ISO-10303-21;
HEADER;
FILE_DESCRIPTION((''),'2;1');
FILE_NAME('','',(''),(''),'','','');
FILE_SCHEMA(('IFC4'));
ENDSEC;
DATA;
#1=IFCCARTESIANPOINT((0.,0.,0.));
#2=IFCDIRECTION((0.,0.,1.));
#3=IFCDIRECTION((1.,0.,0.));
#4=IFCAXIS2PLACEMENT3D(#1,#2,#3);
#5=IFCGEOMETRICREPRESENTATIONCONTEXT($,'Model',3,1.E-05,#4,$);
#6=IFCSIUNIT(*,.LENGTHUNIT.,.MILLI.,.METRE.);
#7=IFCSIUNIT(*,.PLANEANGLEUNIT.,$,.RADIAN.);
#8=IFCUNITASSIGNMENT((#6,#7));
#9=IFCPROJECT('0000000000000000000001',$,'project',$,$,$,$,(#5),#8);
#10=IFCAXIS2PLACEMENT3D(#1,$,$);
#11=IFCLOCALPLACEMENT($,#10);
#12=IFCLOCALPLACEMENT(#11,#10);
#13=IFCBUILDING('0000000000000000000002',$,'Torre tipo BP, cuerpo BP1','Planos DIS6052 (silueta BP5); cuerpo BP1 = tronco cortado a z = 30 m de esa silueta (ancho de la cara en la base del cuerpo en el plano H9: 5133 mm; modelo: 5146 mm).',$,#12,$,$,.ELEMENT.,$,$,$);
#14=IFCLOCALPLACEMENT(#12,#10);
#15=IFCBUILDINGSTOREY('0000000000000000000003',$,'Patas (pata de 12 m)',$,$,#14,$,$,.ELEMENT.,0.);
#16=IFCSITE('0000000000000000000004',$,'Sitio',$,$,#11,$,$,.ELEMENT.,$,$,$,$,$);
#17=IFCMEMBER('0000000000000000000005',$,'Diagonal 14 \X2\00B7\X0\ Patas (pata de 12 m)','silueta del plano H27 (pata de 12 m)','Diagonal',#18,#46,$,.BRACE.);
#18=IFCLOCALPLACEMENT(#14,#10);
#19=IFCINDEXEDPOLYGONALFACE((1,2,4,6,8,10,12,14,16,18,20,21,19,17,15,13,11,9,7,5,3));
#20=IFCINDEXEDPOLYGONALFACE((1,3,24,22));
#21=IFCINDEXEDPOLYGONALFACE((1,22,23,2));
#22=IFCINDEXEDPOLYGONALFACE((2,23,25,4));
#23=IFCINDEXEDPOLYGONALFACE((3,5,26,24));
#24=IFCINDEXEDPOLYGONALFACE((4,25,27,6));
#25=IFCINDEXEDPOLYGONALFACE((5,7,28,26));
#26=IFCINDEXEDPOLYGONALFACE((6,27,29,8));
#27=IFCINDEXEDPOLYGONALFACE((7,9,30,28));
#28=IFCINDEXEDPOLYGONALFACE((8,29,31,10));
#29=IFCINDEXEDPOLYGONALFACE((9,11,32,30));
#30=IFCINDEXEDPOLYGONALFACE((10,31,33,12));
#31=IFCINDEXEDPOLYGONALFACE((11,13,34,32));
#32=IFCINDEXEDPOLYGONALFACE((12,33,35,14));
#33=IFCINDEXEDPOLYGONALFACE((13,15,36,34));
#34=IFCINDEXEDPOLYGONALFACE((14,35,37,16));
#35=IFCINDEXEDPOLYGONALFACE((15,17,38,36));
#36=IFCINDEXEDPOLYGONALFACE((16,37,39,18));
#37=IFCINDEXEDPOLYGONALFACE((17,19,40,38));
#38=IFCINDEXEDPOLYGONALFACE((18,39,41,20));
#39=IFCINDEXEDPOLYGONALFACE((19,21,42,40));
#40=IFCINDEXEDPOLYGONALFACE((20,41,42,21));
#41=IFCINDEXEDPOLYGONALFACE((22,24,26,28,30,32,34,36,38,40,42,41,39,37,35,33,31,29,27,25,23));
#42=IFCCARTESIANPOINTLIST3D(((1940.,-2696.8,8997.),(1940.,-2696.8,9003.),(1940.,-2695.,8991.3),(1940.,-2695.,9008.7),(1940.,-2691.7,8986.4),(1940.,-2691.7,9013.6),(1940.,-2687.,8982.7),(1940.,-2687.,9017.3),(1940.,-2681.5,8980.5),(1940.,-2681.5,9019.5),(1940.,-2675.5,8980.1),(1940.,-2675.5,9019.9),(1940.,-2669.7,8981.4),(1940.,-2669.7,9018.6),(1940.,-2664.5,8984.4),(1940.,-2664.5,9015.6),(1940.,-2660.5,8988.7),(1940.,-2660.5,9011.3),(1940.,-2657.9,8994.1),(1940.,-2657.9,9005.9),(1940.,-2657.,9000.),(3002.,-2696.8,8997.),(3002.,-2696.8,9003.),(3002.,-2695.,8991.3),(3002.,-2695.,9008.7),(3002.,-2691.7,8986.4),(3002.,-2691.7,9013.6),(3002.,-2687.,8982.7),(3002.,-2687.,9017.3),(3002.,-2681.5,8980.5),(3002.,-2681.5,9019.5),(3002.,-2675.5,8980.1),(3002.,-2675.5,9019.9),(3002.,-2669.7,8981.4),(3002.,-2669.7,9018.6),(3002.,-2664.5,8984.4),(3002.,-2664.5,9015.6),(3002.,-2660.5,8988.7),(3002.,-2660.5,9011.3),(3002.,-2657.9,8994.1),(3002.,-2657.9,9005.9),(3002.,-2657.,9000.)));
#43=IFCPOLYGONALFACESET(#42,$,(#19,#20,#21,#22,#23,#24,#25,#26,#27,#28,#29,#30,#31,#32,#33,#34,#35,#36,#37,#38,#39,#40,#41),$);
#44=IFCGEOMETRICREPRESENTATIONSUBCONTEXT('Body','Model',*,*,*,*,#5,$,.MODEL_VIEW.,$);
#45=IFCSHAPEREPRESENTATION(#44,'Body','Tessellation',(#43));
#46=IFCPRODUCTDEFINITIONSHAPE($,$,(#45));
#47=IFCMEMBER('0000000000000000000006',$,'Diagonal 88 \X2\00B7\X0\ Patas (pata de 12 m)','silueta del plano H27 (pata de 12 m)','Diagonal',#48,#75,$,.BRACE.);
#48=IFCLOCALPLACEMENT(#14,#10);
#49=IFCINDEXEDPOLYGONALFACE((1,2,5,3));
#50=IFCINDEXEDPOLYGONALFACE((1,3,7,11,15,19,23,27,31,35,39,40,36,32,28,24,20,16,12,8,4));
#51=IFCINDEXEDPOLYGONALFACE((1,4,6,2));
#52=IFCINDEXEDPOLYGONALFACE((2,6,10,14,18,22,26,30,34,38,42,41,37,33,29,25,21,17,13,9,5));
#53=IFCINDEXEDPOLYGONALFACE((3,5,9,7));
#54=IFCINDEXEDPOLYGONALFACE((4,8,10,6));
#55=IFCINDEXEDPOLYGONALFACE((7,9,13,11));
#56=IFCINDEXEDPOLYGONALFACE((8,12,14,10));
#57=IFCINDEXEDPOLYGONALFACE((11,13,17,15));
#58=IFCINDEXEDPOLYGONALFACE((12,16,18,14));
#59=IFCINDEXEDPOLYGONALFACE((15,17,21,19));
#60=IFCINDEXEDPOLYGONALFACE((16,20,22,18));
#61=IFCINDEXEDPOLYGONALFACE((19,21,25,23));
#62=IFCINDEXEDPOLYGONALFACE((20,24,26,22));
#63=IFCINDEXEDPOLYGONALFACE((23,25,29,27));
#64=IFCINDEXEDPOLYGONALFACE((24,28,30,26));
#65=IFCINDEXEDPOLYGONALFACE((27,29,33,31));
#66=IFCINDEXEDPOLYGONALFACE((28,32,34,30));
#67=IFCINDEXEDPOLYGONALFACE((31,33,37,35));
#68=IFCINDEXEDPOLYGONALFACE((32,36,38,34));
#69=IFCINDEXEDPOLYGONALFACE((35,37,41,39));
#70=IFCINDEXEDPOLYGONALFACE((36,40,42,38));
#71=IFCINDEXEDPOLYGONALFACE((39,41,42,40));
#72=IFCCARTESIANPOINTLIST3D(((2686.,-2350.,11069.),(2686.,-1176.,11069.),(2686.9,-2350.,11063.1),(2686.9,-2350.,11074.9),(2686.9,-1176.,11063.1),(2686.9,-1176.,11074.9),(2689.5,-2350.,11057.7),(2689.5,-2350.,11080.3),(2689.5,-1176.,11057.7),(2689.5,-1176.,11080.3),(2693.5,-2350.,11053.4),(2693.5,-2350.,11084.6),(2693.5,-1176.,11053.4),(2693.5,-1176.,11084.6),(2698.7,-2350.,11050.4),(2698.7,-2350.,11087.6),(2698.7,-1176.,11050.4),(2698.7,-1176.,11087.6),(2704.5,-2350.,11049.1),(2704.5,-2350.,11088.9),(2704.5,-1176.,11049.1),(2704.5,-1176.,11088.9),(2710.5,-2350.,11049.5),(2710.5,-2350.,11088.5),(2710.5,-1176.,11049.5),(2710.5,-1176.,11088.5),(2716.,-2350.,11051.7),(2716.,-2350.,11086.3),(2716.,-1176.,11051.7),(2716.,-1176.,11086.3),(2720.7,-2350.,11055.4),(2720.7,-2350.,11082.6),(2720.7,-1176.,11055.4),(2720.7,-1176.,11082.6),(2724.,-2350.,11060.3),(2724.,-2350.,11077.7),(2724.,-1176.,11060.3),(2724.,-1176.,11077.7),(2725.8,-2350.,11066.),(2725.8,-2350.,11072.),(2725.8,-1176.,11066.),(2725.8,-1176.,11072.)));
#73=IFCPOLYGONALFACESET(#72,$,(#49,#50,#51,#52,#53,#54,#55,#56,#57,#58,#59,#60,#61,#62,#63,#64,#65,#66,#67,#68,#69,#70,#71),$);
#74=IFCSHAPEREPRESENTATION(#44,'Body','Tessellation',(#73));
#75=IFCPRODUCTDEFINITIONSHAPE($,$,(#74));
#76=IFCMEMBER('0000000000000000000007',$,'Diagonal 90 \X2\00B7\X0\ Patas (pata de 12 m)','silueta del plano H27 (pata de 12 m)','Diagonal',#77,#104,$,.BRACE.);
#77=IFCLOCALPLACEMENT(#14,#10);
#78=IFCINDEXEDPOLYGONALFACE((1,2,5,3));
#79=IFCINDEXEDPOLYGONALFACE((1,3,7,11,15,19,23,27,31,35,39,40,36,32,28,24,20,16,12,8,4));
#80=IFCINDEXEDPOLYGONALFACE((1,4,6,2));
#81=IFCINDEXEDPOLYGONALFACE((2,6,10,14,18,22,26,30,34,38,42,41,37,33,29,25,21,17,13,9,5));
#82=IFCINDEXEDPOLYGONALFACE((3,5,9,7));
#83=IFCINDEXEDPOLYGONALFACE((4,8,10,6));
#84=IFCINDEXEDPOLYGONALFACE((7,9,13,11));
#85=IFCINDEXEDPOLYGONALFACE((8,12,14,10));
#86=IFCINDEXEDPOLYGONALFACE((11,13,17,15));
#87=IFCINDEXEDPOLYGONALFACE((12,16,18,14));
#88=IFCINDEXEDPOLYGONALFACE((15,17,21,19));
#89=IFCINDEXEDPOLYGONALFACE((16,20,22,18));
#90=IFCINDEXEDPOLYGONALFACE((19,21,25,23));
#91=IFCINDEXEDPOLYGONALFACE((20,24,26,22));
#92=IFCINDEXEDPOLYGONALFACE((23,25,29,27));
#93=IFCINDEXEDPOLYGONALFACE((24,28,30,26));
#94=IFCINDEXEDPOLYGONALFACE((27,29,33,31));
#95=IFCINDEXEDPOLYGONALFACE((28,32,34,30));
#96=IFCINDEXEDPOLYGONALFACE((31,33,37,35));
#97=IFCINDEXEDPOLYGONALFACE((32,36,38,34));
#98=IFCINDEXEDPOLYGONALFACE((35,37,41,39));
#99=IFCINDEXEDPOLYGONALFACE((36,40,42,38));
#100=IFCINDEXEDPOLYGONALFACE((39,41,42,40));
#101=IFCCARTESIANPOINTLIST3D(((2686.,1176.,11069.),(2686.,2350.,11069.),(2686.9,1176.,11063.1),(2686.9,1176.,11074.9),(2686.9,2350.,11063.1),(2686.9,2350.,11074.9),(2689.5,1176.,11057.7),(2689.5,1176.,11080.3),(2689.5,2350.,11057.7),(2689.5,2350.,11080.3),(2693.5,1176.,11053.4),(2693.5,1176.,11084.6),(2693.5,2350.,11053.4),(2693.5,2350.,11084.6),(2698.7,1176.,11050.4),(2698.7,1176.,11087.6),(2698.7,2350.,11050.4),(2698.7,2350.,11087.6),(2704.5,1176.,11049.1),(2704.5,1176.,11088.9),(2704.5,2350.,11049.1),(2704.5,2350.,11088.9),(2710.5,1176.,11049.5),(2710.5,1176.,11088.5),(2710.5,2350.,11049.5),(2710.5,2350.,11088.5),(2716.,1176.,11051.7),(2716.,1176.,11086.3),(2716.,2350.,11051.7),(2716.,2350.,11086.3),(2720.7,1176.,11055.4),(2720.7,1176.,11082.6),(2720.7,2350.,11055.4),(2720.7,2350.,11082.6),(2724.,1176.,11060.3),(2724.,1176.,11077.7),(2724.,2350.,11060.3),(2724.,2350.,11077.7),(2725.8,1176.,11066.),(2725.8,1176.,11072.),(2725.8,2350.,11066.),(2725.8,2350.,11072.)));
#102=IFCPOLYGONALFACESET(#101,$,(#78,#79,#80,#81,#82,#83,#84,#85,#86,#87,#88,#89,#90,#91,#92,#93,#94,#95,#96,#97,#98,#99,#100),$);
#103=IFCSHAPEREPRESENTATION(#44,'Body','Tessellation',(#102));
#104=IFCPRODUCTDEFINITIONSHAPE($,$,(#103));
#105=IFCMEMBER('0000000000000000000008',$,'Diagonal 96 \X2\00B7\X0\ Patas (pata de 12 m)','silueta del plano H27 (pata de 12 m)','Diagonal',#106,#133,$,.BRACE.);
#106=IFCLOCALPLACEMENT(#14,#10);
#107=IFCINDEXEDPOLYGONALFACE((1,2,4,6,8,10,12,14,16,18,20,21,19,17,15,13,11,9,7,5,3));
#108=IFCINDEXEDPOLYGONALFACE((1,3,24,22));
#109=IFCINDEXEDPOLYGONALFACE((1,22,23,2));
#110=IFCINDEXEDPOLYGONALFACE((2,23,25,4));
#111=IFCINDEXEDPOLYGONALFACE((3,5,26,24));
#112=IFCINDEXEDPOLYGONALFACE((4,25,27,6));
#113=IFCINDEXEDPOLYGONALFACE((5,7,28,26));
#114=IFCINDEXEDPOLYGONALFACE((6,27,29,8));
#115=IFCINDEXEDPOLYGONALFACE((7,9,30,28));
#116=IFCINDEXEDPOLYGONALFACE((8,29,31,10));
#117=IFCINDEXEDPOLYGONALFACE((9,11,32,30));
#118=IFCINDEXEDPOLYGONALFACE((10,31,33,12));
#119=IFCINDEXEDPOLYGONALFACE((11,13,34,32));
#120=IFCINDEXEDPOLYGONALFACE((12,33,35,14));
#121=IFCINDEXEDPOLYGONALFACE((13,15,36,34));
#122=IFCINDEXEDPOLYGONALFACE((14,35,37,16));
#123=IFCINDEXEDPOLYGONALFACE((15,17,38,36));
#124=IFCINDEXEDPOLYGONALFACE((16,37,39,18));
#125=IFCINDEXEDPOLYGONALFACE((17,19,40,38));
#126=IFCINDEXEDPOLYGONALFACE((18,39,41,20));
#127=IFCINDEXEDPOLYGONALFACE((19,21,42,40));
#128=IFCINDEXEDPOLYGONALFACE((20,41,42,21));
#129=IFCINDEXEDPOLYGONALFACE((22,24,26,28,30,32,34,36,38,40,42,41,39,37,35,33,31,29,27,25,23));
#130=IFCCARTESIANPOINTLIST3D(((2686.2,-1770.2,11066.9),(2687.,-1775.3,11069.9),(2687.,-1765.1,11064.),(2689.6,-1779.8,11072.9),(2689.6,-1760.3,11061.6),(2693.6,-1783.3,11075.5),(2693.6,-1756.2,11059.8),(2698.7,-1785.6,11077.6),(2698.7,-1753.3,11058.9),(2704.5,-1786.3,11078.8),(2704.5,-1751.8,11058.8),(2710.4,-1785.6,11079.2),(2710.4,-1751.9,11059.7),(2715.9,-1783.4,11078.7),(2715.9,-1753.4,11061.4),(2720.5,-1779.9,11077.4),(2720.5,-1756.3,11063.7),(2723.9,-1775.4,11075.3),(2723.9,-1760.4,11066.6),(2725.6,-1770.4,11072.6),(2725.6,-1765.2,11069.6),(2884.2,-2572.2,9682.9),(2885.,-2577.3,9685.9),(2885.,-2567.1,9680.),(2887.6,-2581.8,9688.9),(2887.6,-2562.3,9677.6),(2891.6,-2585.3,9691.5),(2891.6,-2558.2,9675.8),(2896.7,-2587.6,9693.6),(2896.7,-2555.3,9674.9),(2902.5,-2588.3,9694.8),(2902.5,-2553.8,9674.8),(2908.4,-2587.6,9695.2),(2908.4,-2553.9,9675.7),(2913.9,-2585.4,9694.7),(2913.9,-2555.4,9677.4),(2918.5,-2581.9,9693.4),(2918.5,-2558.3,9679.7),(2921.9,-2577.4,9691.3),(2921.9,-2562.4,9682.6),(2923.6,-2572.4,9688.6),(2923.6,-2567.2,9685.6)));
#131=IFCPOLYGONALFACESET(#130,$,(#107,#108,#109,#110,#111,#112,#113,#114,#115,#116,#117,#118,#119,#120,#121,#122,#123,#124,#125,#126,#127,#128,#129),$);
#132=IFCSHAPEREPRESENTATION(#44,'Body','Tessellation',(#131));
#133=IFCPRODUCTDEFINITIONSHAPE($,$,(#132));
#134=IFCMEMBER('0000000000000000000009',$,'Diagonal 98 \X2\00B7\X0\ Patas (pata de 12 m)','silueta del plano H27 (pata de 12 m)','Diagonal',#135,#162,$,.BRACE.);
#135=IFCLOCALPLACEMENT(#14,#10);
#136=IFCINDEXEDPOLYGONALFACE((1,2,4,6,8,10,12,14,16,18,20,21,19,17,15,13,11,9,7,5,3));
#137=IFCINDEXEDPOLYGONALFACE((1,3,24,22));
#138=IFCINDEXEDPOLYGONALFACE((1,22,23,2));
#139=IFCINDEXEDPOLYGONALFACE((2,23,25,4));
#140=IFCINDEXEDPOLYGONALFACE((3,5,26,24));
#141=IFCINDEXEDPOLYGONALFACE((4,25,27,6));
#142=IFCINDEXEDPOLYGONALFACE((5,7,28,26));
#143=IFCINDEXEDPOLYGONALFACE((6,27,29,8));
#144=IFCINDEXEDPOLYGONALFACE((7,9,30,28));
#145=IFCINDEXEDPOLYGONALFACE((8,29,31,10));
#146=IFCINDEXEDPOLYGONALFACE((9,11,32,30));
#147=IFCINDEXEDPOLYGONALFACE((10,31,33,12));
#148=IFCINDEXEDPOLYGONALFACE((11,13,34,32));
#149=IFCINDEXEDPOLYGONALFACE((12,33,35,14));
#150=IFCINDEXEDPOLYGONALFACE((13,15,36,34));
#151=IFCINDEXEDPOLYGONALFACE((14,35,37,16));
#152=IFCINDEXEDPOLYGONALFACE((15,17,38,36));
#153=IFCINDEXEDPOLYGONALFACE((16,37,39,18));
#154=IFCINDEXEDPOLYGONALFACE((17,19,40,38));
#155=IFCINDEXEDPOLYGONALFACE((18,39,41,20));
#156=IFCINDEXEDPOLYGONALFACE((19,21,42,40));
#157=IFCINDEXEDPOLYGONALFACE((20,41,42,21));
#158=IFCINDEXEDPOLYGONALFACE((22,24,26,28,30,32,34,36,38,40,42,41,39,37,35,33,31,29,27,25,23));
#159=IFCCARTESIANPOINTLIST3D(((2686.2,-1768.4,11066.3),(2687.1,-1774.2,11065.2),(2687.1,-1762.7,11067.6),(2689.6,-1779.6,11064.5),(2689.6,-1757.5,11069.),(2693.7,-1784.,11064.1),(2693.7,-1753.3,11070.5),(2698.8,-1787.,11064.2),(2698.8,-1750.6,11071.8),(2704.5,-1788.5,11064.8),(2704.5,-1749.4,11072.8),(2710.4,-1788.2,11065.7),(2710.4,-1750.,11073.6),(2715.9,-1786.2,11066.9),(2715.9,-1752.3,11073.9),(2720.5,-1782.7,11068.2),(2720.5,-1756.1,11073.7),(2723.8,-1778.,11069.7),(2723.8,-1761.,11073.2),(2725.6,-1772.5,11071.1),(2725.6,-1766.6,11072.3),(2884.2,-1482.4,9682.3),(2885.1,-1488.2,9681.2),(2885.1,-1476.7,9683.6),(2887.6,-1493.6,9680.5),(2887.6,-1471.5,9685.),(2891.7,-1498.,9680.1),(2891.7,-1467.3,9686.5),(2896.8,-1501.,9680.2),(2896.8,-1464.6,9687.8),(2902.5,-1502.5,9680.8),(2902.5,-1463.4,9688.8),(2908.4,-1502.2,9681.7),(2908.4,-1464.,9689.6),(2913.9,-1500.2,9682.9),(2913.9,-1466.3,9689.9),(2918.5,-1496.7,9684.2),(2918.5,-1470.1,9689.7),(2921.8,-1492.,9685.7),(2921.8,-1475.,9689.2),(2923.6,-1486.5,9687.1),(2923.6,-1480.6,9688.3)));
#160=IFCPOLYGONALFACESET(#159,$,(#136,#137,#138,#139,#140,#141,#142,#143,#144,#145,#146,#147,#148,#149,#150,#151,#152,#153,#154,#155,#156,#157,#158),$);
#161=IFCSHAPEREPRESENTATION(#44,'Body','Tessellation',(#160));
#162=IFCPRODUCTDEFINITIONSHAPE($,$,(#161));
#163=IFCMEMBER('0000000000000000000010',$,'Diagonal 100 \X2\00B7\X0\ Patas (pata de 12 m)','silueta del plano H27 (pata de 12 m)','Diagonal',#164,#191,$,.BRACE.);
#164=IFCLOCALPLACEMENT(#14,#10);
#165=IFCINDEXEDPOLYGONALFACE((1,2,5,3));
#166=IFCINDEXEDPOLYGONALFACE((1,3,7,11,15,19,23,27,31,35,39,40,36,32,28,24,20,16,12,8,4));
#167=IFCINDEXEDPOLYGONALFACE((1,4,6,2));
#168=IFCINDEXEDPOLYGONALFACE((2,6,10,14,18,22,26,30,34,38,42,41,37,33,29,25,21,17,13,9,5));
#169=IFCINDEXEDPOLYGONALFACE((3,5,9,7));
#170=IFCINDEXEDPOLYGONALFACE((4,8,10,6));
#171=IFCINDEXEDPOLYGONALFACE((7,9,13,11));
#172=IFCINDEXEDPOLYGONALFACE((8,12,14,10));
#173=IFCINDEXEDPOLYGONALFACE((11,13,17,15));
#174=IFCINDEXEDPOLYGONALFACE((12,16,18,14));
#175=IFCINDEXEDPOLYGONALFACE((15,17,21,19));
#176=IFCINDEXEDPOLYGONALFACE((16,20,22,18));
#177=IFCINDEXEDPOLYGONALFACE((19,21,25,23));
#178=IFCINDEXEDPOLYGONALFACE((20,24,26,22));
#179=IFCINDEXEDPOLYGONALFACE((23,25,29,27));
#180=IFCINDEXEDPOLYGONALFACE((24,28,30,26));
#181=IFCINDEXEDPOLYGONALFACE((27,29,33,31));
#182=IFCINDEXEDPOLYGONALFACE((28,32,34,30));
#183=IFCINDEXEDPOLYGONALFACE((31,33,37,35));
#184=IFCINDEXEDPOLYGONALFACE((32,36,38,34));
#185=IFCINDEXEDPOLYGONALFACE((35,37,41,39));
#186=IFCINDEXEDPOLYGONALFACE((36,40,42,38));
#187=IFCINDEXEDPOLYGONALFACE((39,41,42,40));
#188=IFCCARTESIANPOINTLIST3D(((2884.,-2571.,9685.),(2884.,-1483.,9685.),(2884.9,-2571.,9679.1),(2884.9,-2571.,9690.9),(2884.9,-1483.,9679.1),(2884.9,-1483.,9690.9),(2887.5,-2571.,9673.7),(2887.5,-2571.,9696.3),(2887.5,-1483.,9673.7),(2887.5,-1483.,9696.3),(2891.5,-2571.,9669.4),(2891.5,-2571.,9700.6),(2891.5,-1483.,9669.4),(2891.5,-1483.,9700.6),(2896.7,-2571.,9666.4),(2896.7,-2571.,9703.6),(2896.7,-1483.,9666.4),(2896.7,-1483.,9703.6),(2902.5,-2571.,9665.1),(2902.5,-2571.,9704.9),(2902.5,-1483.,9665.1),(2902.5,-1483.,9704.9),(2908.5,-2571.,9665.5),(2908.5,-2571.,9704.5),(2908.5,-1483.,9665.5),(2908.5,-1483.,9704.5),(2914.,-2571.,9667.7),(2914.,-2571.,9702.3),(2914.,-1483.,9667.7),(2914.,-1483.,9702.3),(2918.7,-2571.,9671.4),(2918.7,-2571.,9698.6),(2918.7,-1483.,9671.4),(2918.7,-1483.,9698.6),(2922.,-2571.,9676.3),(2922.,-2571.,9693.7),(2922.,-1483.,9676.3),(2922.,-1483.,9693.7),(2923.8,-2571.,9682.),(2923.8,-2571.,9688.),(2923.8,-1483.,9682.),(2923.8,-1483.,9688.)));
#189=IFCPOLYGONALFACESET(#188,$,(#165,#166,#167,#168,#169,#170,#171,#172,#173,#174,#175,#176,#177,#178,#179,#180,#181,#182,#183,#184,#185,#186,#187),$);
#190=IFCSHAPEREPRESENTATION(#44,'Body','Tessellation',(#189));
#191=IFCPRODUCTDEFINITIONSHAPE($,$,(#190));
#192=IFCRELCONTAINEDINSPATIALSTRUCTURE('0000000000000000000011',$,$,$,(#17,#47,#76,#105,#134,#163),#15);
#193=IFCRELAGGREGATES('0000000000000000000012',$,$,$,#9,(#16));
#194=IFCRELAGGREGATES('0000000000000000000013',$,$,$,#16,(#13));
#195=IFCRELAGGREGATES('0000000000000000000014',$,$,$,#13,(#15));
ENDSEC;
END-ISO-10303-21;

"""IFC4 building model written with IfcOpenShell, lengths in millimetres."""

from ifc_helpers import new_model, si_unit, frame, origin, origin_with_axes, place, context, subcontext, project, spatial, circle, extrude, element, save


model = new_model("IFC4")

# Units and contexts
model_context = context("Model", 3, precision=1e-05, world=origin_with_axes())
body_context = subcontext(model_context, "Body", "Model", "MODEL_VIEW")
ifc_project = project(units=[si_unit("LENGTHUNIT", "METRE", prefix="MILLI"), si_unit("PLANEANGLEUNIT", "RADIAN")], contexts=[model_context])

# Site, building, storey
site_placement = place(None, origin())
site = spatial("IfcSite", under=ifc_project, at=site_placement, Name="Sitio", CompositionType="ELEMENT")
building_placement = place(site_placement, origin())
building = spatial("IfcBuilding", under=site, at=building_placement, Name="Torre tipo BP, cuerpo BP1", Description="Planos DIS6052 (silueta BP5); cuerpo BP1 = tronco cortado a z = 30 m de esa silueta (ancho de la cara en la base del cuerpo en el plano H9: 5133 mm; modelo: 5146 mm).", CompositionType="ELEMENT")
storey_placement = place(building_placement, origin())
storey = spatial("IfcBuildingStorey", under=building, at=storey_placement, Name="Patas (pata de 12 m)", CompositionType="ELEMENT", Elevation=0.0)

# Members
for number, where, z_axis, x_axis, name in (
    (1, (3002.0, -2677.0, 9000.0), (-1.0, 0.0, 0.0), (0.0, 1.0, 0.0), "Diagonal 14 · Patas (pata de 12 m)"),
):
    element("IfcMember", number, at=place(storey_placement, frame(where, z_axis=z_axis, x_axis=x_axis)), inside=storey, Name=name, Description="silueta del plano H27 (pata de 12 m)", ObjectType="Diagonal", PredefinedType="BRACE", context=body_context, shape_type="SweptSolid", body=[
        extrude(circle(Radius=20.0), None, (0.0, 0.0, 1.0), 1062.0),
    ])
for number, where, z_axis, x_axis, name in (
    (2, (2706.0, -2350.0, 11069.0), (0.0, 1.0, 0.0), (-1.0, 0.0, 0.0), "Diagonal 88 · Patas (pata de 12 m)"),
    (3, (2706.0, 2350.0, 11069.0), (0.0, -1.0, 0.0), (-1.0, 0.0, 0.0), "Diagonal 90 · Patas (pata de 12 m)"),
):
    element("IfcMember", number, at=place(storey_placement, frame(where, z_axis=z_axis, x_axis=x_axis)), inside=storey, Name=name, Description="silueta del plano H27 (pata de 12 m)", ObjectType="Diagonal", PredefinedType="BRACE", context=body_context, shape_type="SweptSolid", body=[
        extrude(circle(Radius=20.0), None, (0.0, 0.0, 1.0), 1174.0),
    ])
member_1_placement = place(storey_placement, frame((2904.0, -2571.0, 9685.0), z_axis=(-0.122845, 0.497584, 0.858673), x_axis=(-0.992426, -0.061592, -0.106289)))
element("IfcMember", 4, at=member_1_placement, inside=storey, Name="Diagonal 96 · Patas (pata de 12 m)", Description="silueta del plano H27 (pata de 12 m)", ObjectType="Diagonal", PredefinedType="BRACE", context=body_context, shape_type="SweptSolid", body=[
    extrude(circle(Radius=20.0), None, (0.0, 0.0, 1.0), 1611.8),
])
member_2_placement = place(storey_placement, frame((2706.0, -1769.0, 11069.0), z_axis=(0.138748, 0.200414, -0.969837), x_axis=(-0.990328, 0.028079, -0.135877)))
element("IfcMember", 5, at=member_2_placement, inside=storey, Name="Diagonal 98 · Patas (pata de 12 m)", Description="silueta del plano H27 (pata de 12 m)", ObjectType="Diagonal", PredefinedType="BRACE", context=body_context, shape_type="SweptSolid", body=[
    extrude(circle(Radius=20.0), None, (0.0, 0.0, 1.0), 1427.0),
])
member_3_placement = place(storey_placement, frame((2904.0, -1483.0, 9685.0), z_axis=(0.0, -1.0, 0.0), x_axis=(-1.0, 0.0, 0.0)))
element("IfcMember", 6, at=member_3_placement, inside=storey, Name="Diagonal 100 · Patas (pata de 12 m)", Description="silueta del plano H27 (pata de 12 m)", ObjectType="Diagonal", PredefinedType="BRACE", context=body_context, shape_type="SweptSolid", body=[
    extrude(circle(Radius=20.0), None, (0.0, 0.0, 1.0), 1088.0),
])

save(model, "model.ifc")
